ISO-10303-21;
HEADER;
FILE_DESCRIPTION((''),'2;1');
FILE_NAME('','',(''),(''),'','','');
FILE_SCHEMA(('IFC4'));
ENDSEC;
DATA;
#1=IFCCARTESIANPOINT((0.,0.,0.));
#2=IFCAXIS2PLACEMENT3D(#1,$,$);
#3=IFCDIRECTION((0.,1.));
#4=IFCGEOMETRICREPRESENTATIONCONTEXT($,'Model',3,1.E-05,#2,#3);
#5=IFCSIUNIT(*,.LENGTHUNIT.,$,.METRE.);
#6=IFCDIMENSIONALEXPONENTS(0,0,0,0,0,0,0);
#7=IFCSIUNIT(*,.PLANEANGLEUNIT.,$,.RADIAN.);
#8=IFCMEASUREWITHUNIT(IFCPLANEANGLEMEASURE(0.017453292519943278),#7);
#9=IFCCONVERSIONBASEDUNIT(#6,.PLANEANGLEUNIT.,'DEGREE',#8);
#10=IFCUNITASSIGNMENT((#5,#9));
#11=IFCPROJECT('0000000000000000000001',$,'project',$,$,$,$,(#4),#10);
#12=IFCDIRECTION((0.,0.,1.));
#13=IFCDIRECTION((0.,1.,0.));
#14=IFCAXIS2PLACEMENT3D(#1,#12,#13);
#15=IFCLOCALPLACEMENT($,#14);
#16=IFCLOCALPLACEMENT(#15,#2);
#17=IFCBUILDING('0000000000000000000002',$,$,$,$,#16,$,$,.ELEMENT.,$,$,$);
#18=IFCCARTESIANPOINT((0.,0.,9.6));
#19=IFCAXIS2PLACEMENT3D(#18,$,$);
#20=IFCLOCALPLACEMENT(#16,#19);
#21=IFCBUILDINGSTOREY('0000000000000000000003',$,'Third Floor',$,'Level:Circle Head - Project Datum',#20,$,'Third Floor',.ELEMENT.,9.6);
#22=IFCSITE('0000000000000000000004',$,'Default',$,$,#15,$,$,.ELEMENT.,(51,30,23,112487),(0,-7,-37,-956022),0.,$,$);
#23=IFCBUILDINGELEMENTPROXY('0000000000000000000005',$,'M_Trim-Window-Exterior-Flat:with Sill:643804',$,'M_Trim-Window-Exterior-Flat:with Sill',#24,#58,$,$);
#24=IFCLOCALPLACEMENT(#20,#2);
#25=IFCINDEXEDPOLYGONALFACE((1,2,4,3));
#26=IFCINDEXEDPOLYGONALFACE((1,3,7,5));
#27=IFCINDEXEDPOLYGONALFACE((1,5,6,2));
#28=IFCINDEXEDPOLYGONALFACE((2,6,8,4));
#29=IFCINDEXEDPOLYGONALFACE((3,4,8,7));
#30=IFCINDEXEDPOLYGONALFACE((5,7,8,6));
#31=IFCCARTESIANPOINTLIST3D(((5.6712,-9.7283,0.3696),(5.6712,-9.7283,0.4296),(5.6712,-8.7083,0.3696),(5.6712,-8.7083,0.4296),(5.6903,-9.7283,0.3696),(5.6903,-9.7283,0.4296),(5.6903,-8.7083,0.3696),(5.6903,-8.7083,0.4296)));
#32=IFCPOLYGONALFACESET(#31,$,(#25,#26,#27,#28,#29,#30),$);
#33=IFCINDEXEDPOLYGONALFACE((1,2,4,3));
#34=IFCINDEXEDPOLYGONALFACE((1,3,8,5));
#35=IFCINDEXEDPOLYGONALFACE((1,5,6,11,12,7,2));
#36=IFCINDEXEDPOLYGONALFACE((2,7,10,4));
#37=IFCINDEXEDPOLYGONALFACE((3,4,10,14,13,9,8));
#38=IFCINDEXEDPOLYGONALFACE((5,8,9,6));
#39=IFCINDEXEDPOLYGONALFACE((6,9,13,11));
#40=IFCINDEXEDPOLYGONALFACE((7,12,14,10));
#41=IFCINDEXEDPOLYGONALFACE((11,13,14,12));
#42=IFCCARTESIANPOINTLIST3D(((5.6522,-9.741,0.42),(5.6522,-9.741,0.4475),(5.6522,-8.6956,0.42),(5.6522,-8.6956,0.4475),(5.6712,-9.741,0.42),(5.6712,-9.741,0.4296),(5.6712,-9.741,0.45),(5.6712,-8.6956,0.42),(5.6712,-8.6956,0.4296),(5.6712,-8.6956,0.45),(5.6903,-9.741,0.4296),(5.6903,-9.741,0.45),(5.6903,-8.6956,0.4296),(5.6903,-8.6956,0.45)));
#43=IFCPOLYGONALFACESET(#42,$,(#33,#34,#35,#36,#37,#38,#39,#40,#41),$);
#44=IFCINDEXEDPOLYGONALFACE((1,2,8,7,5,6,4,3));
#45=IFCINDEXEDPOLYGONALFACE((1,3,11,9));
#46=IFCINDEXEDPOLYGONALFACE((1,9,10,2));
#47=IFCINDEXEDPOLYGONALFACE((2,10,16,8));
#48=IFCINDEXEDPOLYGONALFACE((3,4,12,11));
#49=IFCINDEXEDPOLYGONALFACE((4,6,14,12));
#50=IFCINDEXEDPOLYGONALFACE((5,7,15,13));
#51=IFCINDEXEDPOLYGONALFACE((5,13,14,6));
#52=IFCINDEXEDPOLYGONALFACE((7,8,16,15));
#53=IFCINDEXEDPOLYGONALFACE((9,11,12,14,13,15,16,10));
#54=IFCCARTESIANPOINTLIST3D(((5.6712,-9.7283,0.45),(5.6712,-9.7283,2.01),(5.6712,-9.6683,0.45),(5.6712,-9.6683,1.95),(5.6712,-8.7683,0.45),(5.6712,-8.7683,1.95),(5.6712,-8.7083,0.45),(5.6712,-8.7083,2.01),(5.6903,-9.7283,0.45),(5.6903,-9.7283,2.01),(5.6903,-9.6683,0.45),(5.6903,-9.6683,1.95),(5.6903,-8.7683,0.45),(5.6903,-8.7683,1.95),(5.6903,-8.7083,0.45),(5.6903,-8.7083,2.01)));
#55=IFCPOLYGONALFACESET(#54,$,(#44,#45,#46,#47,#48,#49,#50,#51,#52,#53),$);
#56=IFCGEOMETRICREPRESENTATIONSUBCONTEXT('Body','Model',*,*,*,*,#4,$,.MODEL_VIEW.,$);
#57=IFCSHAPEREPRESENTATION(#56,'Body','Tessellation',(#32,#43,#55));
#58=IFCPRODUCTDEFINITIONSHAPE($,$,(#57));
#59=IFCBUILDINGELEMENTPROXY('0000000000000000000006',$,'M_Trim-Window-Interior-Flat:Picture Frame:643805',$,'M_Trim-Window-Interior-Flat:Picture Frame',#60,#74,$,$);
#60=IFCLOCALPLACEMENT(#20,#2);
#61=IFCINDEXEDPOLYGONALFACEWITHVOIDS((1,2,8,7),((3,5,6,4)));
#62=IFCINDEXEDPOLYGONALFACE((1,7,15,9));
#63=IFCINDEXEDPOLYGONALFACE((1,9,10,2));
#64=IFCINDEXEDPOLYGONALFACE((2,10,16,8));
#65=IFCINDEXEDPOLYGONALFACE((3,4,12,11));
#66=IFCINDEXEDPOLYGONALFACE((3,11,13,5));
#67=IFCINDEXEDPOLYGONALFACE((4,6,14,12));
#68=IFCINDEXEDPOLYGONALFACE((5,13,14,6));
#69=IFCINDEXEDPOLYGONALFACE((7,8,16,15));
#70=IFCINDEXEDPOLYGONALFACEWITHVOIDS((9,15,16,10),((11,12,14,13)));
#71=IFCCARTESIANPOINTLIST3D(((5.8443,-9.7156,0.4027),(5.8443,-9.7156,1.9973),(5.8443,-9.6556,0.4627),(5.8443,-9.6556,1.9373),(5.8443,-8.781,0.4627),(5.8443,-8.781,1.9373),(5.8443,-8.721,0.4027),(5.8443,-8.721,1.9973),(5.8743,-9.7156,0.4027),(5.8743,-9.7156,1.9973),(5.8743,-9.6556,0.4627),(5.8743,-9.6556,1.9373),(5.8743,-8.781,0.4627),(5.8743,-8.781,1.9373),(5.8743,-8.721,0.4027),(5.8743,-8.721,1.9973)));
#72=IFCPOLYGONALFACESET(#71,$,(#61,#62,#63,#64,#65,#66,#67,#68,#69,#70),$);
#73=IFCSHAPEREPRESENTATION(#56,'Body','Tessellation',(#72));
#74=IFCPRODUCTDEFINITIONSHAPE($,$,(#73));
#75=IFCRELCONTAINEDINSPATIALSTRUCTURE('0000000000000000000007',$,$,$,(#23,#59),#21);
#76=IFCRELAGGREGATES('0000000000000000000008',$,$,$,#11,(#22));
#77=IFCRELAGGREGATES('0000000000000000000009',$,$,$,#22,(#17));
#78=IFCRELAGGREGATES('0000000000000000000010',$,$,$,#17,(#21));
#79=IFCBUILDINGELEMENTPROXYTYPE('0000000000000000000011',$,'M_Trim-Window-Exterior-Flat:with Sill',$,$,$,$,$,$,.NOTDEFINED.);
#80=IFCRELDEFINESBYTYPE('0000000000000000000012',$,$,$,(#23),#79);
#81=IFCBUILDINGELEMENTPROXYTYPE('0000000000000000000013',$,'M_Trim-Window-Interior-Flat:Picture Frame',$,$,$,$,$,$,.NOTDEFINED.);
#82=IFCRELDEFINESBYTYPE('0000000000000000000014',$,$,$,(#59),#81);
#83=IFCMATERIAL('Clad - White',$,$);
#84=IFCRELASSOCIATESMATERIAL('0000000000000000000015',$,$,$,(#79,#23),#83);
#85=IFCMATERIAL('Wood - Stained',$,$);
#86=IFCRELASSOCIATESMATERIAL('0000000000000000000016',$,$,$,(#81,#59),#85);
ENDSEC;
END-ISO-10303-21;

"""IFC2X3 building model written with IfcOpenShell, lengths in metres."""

from ifc_helpers import new_model, entity, si_unit, converted_unit, direction, frame, frame_2d, origin, place, context, subcontext, project, spatial, polyline, rectangle, outline, extrude, source, transform, mapped, material, type_object, type_shapes, element, save


model = new_model("IFC2X3")

# Units and contexts
model_context = context("Model", 3, precision=1e-05, world=origin(), true_north=direction((0.0, 1.0)))
body_context = subcontext(model_context, "Body", "Model", "MODEL_VIEW")
ifc_project = project(units=[si_unit("LENGTHUNIT", "METRE"), converted_unit("PLANEANGLEUNIT", "DEGREE", entity("IfcPlaneAngleMeasure", 0.017453292519943278), si_unit("PLANEANGLEUNIT", "RADIAN"), dimensions=[0, 0, 0, 0, 0, 0, 0])], contexts=[model_context])

# Site, building, storey
site_placement = place(None, frame((0.0, 0.0, 0.0), z_axis=(0.0, 0.0, 1.0), x_axis=(0.0, 1.0, 0.0)))
site = spatial("IfcSite", under=ifc_project, at=site_placement, Name="Default", CompositionType="ELEMENT", RefLatitude=(51, 30, 23, 112487), RefLongitude=(0, -7, -37, -956022), RefElevation=0.0)
building_placement = place(site_placement, origin())
building = spatial("IfcBuilding", under=site, at=building_placement, CompositionType="ELEMENT")
storey_placement = place(building_placement, frame((0.0, 0.0, 9.6)))
storey = spatial("IfcBuildingStorey", under=building, at=storey_placement, Name="Third Floor", ObjectType="Level:Circle Head - Project Datum", LongName="Third Floor", CompositionType="ELEMENT", Elevation=9.6)

# Building element proxies
ifc_material_1 = material(Name="Clad - White")
ifc_material_2 = material(Name="Wood - Stained")
building_element_proxy_type_1 = type_object("IfcBuildingElementProxyType", Name="M_Trim-Window-Exterior-Flat:with Sill", PredefinedType="NOTDEFINED", material=ifc_material_1)
shared_shape_1 = source(origin(), body_context, "Body", "SweptSolid", [
    extrude(rectangle(XDim=1.02, YDim=0.06, at=frame_2d((0.0, 0.0), x_axis=(1.0, 0.0))), frame((0.0, -1.5504, 0.0), z_axis=(0.0, 0.0, 1.0), x_axis=(-1.0, 0.0, 0.0)), (0.0, 0.0, 1.0), 0.019),
    extrude(outline(polyline([(-0.019, -0.0152), (0.0, -0.0152), (0.0, -0.0057), (0.019, -0.0057), (0.019, 0.0148), (0.0, 0.0148), (-0.019, 0.0123), (-0.019, -0.0152)])), frame((-0.5227, -1.5148, 0.019), z_axis=(1.0, 0.0, 0.0), x_axis=(0.0, 0.0, -1.0)), (0.0, 0.0, 1.0), 1.0454),
    extrude(outline(polyline([(-0.795, -0.51), (0.765, -0.51), (0.765, -0.45), (-0.735, -0.45), (-0.735, 0.45), (0.765, 0.45), (0.765, 0.51), (-0.795, 0.51), (-0.795, -0.51)])), frame((0.0, -0.735, 0.0), z_axis=(0.0, 0.0, 1.0), x_axis=(0.0, -1.0, 0.0)), (0.0, 0.0, 1.0), 0.019),
])
type_shapes(building_element_proxy_type_1, [shared_shape_1])
proxy_1_placement = place(storey_placement, frame((5.6903, -9.2183, 1.95), z_axis=(-1.0, 0.0, 0.0), x_axis=(0.0, -1.0, 0.0)))
element("IfcBuildingElementProxy", 1, at=proxy_1_placement, inside=storey, type_object=building_element_proxy_type_1, material=ifc_material_1, Name="M_Trim-Window-Exterior-Flat:with Sill:643804", ObjectType="M_Trim-Window-Exterior-Flat:with Sill", context=body_context, shape_type="MappedRepresentation", body=[
    mapped(shared_shape_1, transform((0.0, 0.0, 0.0), scale=1.0)),
])
building_element_proxy_type_2 = type_object("IfcBuildingElementProxyType", Name="M_Trim-Window-Interior-Flat:Picture Frame", PredefinedType="NOTDEFINED", material=ifc_material_2)
shared_shape_2 = source(origin(), body_context, "Body", "SweptSolid", [
    extrude(outline(polyline([(-0.4973, -0.7973), (0.4973, -0.7973), (0.4973, 0.7973), (-0.4973, 0.7973), (-0.4973, -0.7973)]), holes=[polyline([(-0.4373, -0.7373), (-0.4373, 0.7373), (0.4373, 0.7373), (0.4373, -0.7373), (-0.4373, -0.7373)])]), frame((0.0, -0.75, 0.0), z_axis=(0.0, 0.0, 1.0), x_axis=(-1.0, 0.0, 0.0)), (0.0, 0.0, 1.0), 0.03),
])
type_shapes(building_element_proxy_type_2, [shared_shape_2])
proxy_2_placement = place(storey_placement, frame((5.8443, -9.2183, 1.95), z_axis=(1.0, 0.0, 0.0), x_axis=(0.0, 1.0, 0.0)))
element("IfcBuildingElementProxy", 2, at=proxy_2_placement, inside=storey, type_object=building_element_proxy_type_2, material=ifc_material_2, Name="M_Trim-Window-Interior-Flat:Picture Frame:643805", ObjectType="M_Trim-Window-Interior-Flat:Picture Frame", context=body_context, shape_type="MappedRepresentation", body=[
    mapped(shared_shape_2, transform((0.0, 0.0, 0.0), scale=1.0)),
])

save(model, "model.ifc")
